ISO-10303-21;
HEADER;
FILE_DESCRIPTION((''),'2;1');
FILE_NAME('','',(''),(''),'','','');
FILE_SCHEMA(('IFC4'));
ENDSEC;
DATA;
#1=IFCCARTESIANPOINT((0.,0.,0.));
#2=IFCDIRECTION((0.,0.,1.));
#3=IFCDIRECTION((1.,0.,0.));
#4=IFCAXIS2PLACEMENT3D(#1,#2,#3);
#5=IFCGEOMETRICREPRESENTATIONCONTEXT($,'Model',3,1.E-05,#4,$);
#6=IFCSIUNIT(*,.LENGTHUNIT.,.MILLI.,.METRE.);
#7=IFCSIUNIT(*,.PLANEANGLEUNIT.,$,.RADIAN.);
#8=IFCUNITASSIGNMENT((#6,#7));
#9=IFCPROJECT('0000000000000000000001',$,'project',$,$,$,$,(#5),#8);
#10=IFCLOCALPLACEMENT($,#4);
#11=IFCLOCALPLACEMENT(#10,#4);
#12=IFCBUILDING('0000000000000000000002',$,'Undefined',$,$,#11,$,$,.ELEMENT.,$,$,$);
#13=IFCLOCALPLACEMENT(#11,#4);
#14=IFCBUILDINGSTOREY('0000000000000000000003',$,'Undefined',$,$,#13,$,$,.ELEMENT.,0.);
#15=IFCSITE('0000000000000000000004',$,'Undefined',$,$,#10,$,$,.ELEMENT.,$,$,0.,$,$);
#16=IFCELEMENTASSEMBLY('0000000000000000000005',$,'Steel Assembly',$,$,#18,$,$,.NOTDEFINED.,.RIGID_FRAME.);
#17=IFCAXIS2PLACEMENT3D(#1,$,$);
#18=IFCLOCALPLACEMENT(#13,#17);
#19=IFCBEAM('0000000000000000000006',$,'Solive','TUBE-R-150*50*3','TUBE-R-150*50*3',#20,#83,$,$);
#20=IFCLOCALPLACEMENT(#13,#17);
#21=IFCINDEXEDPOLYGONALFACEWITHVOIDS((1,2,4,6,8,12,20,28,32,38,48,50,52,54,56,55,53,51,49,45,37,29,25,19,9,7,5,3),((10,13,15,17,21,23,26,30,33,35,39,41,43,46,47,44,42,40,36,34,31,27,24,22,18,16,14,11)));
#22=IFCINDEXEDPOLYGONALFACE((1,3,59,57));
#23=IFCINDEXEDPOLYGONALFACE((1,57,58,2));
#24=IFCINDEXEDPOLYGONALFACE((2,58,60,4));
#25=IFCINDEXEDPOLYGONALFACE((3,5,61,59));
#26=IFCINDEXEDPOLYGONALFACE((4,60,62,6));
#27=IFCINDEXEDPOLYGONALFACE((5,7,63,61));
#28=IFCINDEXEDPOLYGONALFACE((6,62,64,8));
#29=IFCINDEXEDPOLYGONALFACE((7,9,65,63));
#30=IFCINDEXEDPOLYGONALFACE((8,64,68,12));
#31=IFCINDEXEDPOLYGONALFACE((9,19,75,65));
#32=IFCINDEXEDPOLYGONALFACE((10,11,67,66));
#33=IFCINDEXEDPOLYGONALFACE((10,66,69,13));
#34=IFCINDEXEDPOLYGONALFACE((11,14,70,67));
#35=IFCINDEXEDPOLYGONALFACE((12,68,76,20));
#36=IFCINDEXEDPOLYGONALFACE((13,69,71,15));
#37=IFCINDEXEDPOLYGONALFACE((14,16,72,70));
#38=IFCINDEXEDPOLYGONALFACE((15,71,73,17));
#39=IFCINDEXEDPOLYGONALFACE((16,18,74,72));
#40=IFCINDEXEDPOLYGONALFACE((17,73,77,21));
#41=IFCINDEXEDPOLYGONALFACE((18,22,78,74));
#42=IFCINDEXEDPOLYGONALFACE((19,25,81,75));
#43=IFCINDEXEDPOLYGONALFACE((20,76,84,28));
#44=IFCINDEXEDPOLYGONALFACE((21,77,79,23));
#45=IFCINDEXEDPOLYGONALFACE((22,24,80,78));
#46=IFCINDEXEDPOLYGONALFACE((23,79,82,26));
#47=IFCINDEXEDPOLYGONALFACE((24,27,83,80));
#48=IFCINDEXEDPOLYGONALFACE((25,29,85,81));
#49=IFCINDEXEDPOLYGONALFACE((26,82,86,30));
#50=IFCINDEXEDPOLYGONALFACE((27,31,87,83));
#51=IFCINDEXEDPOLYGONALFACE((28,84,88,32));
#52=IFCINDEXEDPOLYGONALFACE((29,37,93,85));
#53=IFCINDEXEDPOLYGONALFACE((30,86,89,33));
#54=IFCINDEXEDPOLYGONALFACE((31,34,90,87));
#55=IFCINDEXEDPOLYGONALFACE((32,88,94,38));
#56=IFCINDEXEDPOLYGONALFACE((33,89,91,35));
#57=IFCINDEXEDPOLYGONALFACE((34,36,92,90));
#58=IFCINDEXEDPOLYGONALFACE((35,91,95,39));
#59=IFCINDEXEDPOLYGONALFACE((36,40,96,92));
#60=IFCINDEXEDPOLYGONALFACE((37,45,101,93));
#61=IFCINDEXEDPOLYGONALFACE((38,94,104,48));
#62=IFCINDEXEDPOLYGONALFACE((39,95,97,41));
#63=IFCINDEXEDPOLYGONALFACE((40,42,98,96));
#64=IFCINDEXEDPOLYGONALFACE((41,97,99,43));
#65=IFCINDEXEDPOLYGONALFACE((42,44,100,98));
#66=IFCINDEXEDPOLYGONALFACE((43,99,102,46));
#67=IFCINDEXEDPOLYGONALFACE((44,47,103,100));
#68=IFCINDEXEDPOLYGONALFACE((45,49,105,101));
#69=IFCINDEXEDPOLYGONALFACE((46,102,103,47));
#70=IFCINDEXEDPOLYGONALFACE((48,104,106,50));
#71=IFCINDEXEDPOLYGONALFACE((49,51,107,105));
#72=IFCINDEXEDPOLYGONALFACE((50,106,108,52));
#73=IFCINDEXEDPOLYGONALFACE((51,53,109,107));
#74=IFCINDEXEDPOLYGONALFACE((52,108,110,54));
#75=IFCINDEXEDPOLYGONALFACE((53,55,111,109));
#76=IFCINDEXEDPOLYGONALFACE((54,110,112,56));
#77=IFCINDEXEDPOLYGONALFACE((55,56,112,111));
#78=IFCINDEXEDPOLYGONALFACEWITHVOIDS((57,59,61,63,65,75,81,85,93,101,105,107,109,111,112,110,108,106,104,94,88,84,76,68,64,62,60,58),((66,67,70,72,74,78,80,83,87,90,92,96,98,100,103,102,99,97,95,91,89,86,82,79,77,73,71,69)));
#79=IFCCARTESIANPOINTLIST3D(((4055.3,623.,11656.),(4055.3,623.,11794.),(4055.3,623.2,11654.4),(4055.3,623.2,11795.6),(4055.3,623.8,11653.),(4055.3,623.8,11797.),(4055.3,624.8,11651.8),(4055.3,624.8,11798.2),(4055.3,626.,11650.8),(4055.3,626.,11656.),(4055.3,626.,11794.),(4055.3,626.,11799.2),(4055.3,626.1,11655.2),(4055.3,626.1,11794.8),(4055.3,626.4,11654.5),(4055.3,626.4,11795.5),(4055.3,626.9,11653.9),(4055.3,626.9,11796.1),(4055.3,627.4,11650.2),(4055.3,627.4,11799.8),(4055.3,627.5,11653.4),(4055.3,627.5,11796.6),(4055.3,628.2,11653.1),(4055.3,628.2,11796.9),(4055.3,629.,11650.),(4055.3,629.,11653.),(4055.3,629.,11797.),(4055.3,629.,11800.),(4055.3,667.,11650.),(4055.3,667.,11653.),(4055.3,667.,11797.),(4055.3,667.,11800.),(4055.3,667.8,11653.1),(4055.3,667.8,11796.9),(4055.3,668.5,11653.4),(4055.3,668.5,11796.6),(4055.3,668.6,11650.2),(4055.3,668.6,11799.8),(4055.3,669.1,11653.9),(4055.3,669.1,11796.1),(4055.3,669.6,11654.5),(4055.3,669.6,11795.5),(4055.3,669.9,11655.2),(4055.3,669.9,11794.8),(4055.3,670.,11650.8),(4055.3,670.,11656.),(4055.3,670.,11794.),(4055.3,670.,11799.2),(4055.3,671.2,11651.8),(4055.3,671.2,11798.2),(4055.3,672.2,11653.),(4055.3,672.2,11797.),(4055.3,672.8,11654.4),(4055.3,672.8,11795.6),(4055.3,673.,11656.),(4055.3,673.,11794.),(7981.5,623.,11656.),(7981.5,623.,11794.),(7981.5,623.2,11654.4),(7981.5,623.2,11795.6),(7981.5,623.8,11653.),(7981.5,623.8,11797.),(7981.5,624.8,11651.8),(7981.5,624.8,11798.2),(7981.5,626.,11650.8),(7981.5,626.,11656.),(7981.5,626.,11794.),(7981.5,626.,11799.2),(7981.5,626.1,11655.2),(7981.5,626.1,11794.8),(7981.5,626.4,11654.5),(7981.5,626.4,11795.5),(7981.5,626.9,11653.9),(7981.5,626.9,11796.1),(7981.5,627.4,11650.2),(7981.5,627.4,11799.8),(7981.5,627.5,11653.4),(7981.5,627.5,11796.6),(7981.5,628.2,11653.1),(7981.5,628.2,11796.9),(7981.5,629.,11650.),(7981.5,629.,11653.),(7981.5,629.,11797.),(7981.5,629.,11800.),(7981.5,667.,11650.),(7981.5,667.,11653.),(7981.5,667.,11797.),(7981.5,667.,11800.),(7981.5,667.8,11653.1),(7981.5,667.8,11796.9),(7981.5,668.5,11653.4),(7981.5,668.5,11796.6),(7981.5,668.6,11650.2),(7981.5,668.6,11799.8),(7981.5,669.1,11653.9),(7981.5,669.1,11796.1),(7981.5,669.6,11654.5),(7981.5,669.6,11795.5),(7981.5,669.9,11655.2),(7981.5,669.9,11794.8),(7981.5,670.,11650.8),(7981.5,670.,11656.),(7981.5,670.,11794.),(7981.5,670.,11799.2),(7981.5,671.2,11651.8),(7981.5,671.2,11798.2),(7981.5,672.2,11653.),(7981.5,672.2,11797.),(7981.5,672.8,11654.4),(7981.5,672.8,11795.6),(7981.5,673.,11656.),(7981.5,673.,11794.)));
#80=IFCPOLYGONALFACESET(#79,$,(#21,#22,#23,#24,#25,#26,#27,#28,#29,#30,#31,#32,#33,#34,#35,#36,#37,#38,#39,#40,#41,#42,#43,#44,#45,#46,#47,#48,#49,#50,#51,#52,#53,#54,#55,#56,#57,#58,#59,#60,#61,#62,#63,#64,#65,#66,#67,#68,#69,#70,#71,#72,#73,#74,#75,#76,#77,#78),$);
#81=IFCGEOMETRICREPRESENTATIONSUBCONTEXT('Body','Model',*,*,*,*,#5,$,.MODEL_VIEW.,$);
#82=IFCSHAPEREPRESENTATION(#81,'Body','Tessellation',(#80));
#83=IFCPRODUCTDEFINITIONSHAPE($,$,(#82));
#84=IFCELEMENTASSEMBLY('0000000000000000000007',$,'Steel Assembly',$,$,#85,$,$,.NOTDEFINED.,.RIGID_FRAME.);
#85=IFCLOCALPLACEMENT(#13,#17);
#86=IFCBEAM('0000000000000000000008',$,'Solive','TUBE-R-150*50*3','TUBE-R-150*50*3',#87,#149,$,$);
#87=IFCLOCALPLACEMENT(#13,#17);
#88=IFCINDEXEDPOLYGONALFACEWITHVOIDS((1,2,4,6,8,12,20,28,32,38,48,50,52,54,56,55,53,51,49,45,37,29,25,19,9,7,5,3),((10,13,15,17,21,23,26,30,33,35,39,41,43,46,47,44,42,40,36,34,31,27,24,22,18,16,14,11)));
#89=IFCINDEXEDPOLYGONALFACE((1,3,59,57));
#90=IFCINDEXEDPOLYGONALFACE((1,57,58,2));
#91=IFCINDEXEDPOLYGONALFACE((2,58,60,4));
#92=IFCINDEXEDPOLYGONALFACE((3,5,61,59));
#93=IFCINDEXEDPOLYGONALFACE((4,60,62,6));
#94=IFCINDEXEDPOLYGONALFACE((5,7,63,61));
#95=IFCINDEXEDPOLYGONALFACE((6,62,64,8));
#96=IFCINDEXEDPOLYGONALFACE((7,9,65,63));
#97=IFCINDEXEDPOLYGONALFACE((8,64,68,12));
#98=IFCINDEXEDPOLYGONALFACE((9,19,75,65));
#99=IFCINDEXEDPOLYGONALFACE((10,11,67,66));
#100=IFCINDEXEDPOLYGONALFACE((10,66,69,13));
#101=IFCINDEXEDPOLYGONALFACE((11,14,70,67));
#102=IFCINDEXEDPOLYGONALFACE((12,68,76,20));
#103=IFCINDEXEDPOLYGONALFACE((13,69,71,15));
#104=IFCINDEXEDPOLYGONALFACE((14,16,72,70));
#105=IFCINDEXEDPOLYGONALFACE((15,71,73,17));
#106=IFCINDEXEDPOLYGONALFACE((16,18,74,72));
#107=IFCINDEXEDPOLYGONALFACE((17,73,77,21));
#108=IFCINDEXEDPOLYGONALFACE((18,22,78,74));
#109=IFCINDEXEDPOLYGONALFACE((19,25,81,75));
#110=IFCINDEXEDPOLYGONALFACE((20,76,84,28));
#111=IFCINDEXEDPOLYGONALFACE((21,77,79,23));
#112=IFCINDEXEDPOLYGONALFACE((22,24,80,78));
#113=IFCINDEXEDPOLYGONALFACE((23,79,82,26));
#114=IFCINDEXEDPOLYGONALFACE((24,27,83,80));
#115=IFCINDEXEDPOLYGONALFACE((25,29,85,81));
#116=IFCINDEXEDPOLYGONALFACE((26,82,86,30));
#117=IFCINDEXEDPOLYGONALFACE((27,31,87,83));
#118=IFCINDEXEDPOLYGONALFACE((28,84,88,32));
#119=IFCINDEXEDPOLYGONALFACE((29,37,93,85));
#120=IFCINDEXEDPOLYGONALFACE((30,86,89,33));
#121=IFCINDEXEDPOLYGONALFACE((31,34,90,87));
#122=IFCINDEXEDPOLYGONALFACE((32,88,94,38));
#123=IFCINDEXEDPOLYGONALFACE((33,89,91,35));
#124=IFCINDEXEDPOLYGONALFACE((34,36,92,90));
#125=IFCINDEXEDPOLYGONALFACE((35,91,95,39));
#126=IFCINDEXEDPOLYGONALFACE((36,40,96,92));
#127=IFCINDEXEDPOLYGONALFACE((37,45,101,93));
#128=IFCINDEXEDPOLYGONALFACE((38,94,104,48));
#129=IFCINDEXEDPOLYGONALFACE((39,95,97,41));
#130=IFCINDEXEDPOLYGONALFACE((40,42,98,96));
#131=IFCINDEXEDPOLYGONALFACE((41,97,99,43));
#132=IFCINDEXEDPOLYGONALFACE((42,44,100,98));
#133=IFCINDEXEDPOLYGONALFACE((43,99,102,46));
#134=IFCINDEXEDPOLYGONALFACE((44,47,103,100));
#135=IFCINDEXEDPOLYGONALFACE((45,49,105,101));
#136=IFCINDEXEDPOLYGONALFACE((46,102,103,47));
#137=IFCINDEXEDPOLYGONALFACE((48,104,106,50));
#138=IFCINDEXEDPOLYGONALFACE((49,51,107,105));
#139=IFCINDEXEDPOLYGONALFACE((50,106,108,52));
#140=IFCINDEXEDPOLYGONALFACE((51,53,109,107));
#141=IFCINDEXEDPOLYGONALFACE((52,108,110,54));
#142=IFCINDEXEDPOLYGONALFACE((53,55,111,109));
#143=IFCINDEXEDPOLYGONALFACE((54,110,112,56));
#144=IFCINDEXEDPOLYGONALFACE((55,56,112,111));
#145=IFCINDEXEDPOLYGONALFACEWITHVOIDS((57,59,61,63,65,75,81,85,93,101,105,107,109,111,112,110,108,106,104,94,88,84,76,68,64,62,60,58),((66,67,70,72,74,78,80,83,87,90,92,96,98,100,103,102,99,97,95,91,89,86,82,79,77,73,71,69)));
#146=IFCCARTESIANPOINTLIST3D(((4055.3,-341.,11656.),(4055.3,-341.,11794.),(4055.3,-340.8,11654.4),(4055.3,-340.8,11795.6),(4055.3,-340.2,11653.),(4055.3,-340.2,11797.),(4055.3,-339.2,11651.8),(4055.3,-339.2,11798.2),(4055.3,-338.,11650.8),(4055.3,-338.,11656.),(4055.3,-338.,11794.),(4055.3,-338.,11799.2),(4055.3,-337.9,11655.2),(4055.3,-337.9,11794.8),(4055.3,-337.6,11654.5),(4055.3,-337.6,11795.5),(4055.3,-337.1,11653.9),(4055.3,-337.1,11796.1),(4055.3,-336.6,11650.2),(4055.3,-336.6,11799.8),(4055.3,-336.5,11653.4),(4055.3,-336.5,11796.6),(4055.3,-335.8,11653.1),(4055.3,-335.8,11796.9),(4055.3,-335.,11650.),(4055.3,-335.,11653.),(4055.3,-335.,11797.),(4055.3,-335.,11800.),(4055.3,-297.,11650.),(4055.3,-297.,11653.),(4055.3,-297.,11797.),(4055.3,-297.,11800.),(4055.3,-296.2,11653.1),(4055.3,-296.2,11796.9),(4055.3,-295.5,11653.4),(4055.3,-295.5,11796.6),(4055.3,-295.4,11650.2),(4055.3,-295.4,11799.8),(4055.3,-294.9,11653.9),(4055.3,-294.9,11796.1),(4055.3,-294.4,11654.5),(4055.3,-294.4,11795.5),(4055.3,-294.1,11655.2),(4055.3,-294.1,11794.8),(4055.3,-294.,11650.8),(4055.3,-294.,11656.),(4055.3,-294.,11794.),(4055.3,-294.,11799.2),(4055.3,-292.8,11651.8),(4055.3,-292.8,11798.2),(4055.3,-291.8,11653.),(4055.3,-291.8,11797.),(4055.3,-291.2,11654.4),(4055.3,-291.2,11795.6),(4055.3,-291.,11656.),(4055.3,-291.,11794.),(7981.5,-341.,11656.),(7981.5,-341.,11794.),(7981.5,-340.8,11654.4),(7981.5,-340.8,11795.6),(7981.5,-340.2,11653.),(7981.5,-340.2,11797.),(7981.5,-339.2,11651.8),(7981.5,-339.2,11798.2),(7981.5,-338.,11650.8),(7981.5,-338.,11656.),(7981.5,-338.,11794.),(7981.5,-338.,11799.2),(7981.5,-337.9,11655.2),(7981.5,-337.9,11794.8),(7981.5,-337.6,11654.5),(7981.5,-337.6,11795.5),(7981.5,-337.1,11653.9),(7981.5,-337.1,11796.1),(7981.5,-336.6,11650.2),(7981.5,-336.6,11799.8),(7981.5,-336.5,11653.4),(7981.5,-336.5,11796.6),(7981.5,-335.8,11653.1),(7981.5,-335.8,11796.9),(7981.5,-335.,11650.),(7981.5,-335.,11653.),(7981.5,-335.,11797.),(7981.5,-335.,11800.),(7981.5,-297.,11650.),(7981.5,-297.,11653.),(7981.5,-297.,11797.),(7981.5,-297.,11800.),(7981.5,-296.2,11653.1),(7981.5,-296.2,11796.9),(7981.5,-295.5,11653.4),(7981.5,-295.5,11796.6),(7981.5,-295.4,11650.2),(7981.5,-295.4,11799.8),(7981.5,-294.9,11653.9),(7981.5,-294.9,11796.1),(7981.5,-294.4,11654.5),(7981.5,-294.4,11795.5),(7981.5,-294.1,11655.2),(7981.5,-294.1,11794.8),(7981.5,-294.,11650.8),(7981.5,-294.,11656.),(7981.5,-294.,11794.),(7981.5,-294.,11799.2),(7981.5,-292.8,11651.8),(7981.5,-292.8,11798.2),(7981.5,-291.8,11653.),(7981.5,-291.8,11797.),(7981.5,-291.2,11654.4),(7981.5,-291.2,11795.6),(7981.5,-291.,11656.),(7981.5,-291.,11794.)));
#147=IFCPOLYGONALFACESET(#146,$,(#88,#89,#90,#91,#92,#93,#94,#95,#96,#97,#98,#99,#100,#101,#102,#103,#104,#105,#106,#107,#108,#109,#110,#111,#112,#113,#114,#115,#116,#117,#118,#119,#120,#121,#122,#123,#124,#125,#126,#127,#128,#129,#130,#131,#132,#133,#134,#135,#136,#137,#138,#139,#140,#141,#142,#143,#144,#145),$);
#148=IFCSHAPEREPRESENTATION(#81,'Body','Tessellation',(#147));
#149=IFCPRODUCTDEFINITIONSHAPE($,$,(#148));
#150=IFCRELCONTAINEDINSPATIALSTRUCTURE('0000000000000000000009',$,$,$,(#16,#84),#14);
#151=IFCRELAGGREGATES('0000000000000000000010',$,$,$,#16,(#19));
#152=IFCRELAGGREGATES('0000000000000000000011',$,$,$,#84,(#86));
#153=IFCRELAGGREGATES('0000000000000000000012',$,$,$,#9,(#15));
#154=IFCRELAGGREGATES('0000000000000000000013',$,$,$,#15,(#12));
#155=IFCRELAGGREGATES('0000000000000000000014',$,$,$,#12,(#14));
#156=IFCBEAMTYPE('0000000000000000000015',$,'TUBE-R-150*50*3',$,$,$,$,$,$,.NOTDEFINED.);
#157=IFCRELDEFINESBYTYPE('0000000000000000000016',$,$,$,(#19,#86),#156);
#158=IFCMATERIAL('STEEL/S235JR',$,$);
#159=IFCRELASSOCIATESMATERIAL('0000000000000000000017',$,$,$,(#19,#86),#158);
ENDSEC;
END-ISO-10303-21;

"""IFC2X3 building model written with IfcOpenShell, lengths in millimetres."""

from ifc_helpers import new_model, si_unit, frame, origin_with_axes, origin_2d_with_axis, place, context, subcontext, project, spatial, hollow_rectangle, extrude, material, type_object, element, aggregate, save


model = new_model("IFC2X3")

# Units and contexts
model_context = context("Model", 3, precision=1e-05, world=origin_with_axes())
body_context = subcontext(model_context, "Body", "Model", "MODEL_VIEW")
ifc_project = project(units=[si_unit("LENGTHUNIT", "METRE", prefix="MILLI"), si_unit("PLANEANGLEUNIT", "RADIAN")], contexts=[model_context])

# Site, building, storey
site_placement = place(None, origin_with_axes())
site = spatial("IfcSite", under=ifc_project, at=site_placement, Name="Undefined", CompositionType="ELEMENT", RefElevation=0.0)
building_placement = place(site_placement, origin_with_axes())
building = spatial("IfcBuilding", under=site, at=building_placement, Name="Undefined", CompositionType="ELEMENT")
storey_placement = place(building_placement, origin_with_axes())
storey = spatial("IfcBuildingStorey", under=building, at=storey_placement, Name="Undefined", CompositionType="ELEMENT", Elevation=0.0)

# Element assemblies, beams
ifc_material_1 = material(Name="STEEL/S235JR")
beam_type_1 = type_object("IfcBeamType", Name="TUBE-R-150*50*3", PredefinedType="NOTDEFINED")
assembly_1_placement = place(storey_placement, origin_with_axes())
assembly_1 = element("IfcElementAssembly", 1, at=assembly_1_placement, inside=storey, Name="Steel Assembly", AssemblyPlace="NOTDEFINED", PredefinedType="RIGID_FRAME")
beam_1_placement = place(assembly_1_placement, frame((4055.3, 648.0, 11725.0), z_axis=(0.0, 0.0, 1.0), x_axis=(1.0, 0.0, 0.0)))
beam_1 = element("IfcBeam", 2, at=beam_1_placement, type_object=beam_type_1, material=ifc_material_1, Name="Solive", Description="TUBE-R-150*50*3", ObjectType="TUBE-R-150*50*3", context=body_context, shape_type="SweptSolid", body=[
    extrude(hollow_rectangle(XDim=50.0, YDim=150.0, WallThickness=3.0, InnerFilletRadius=3.0, OuterFilletRadius=6.0, at=origin_2d_with_axis()), frame((3926.2, 0.0, 0.0), z_axis=(-1.0, 0.0, 0.0), x_axis=(0.0, -1.0, 0.0)), (0.0, 0.0, 1.0), 3926.2),
])
aggregate(assembly_1, [beam_1])
assembly_2_placement = place(storey_placement, origin_with_axes())
assembly_2 = element("IfcElementAssembly", 3, at=assembly_2_placement, inside=storey, Name="Steel Assembly", AssemblyPlace="NOTDEFINED", PredefinedType="RIGID_FRAME")
beam_2_placement = place(assembly_2_placement, frame((4055.3, -316.0, 11725.0), z_axis=(0.0, 0.0, 1.0), x_axis=(1.0, 0.0, 0.0)))
beam_2 = element("IfcBeam", 4, at=beam_2_placement, type_object=beam_type_1, material=ifc_material_1, Name="Solive", Description="TUBE-R-150*50*3", ObjectType="TUBE-R-150*50*3", context=body_context, shape_type="SweptSolid", body=[
    extrude(hollow_rectangle(XDim=50.0, YDim=150.0, WallThickness=3.0, InnerFilletRadius=3.0, OuterFilletRadius=6.0, at=origin_2d_with_axis()), frame((3926.2, 0.0, 0.0), z_axis=(-1.0, 0.0, 0.0), x_axis=(0.0, -1.0, 0.0)), (0.0, 0.0, 1.0), 3926.2),
])
aggregate(assembly_2, [beam_2])

save(model, "model.ifc")
